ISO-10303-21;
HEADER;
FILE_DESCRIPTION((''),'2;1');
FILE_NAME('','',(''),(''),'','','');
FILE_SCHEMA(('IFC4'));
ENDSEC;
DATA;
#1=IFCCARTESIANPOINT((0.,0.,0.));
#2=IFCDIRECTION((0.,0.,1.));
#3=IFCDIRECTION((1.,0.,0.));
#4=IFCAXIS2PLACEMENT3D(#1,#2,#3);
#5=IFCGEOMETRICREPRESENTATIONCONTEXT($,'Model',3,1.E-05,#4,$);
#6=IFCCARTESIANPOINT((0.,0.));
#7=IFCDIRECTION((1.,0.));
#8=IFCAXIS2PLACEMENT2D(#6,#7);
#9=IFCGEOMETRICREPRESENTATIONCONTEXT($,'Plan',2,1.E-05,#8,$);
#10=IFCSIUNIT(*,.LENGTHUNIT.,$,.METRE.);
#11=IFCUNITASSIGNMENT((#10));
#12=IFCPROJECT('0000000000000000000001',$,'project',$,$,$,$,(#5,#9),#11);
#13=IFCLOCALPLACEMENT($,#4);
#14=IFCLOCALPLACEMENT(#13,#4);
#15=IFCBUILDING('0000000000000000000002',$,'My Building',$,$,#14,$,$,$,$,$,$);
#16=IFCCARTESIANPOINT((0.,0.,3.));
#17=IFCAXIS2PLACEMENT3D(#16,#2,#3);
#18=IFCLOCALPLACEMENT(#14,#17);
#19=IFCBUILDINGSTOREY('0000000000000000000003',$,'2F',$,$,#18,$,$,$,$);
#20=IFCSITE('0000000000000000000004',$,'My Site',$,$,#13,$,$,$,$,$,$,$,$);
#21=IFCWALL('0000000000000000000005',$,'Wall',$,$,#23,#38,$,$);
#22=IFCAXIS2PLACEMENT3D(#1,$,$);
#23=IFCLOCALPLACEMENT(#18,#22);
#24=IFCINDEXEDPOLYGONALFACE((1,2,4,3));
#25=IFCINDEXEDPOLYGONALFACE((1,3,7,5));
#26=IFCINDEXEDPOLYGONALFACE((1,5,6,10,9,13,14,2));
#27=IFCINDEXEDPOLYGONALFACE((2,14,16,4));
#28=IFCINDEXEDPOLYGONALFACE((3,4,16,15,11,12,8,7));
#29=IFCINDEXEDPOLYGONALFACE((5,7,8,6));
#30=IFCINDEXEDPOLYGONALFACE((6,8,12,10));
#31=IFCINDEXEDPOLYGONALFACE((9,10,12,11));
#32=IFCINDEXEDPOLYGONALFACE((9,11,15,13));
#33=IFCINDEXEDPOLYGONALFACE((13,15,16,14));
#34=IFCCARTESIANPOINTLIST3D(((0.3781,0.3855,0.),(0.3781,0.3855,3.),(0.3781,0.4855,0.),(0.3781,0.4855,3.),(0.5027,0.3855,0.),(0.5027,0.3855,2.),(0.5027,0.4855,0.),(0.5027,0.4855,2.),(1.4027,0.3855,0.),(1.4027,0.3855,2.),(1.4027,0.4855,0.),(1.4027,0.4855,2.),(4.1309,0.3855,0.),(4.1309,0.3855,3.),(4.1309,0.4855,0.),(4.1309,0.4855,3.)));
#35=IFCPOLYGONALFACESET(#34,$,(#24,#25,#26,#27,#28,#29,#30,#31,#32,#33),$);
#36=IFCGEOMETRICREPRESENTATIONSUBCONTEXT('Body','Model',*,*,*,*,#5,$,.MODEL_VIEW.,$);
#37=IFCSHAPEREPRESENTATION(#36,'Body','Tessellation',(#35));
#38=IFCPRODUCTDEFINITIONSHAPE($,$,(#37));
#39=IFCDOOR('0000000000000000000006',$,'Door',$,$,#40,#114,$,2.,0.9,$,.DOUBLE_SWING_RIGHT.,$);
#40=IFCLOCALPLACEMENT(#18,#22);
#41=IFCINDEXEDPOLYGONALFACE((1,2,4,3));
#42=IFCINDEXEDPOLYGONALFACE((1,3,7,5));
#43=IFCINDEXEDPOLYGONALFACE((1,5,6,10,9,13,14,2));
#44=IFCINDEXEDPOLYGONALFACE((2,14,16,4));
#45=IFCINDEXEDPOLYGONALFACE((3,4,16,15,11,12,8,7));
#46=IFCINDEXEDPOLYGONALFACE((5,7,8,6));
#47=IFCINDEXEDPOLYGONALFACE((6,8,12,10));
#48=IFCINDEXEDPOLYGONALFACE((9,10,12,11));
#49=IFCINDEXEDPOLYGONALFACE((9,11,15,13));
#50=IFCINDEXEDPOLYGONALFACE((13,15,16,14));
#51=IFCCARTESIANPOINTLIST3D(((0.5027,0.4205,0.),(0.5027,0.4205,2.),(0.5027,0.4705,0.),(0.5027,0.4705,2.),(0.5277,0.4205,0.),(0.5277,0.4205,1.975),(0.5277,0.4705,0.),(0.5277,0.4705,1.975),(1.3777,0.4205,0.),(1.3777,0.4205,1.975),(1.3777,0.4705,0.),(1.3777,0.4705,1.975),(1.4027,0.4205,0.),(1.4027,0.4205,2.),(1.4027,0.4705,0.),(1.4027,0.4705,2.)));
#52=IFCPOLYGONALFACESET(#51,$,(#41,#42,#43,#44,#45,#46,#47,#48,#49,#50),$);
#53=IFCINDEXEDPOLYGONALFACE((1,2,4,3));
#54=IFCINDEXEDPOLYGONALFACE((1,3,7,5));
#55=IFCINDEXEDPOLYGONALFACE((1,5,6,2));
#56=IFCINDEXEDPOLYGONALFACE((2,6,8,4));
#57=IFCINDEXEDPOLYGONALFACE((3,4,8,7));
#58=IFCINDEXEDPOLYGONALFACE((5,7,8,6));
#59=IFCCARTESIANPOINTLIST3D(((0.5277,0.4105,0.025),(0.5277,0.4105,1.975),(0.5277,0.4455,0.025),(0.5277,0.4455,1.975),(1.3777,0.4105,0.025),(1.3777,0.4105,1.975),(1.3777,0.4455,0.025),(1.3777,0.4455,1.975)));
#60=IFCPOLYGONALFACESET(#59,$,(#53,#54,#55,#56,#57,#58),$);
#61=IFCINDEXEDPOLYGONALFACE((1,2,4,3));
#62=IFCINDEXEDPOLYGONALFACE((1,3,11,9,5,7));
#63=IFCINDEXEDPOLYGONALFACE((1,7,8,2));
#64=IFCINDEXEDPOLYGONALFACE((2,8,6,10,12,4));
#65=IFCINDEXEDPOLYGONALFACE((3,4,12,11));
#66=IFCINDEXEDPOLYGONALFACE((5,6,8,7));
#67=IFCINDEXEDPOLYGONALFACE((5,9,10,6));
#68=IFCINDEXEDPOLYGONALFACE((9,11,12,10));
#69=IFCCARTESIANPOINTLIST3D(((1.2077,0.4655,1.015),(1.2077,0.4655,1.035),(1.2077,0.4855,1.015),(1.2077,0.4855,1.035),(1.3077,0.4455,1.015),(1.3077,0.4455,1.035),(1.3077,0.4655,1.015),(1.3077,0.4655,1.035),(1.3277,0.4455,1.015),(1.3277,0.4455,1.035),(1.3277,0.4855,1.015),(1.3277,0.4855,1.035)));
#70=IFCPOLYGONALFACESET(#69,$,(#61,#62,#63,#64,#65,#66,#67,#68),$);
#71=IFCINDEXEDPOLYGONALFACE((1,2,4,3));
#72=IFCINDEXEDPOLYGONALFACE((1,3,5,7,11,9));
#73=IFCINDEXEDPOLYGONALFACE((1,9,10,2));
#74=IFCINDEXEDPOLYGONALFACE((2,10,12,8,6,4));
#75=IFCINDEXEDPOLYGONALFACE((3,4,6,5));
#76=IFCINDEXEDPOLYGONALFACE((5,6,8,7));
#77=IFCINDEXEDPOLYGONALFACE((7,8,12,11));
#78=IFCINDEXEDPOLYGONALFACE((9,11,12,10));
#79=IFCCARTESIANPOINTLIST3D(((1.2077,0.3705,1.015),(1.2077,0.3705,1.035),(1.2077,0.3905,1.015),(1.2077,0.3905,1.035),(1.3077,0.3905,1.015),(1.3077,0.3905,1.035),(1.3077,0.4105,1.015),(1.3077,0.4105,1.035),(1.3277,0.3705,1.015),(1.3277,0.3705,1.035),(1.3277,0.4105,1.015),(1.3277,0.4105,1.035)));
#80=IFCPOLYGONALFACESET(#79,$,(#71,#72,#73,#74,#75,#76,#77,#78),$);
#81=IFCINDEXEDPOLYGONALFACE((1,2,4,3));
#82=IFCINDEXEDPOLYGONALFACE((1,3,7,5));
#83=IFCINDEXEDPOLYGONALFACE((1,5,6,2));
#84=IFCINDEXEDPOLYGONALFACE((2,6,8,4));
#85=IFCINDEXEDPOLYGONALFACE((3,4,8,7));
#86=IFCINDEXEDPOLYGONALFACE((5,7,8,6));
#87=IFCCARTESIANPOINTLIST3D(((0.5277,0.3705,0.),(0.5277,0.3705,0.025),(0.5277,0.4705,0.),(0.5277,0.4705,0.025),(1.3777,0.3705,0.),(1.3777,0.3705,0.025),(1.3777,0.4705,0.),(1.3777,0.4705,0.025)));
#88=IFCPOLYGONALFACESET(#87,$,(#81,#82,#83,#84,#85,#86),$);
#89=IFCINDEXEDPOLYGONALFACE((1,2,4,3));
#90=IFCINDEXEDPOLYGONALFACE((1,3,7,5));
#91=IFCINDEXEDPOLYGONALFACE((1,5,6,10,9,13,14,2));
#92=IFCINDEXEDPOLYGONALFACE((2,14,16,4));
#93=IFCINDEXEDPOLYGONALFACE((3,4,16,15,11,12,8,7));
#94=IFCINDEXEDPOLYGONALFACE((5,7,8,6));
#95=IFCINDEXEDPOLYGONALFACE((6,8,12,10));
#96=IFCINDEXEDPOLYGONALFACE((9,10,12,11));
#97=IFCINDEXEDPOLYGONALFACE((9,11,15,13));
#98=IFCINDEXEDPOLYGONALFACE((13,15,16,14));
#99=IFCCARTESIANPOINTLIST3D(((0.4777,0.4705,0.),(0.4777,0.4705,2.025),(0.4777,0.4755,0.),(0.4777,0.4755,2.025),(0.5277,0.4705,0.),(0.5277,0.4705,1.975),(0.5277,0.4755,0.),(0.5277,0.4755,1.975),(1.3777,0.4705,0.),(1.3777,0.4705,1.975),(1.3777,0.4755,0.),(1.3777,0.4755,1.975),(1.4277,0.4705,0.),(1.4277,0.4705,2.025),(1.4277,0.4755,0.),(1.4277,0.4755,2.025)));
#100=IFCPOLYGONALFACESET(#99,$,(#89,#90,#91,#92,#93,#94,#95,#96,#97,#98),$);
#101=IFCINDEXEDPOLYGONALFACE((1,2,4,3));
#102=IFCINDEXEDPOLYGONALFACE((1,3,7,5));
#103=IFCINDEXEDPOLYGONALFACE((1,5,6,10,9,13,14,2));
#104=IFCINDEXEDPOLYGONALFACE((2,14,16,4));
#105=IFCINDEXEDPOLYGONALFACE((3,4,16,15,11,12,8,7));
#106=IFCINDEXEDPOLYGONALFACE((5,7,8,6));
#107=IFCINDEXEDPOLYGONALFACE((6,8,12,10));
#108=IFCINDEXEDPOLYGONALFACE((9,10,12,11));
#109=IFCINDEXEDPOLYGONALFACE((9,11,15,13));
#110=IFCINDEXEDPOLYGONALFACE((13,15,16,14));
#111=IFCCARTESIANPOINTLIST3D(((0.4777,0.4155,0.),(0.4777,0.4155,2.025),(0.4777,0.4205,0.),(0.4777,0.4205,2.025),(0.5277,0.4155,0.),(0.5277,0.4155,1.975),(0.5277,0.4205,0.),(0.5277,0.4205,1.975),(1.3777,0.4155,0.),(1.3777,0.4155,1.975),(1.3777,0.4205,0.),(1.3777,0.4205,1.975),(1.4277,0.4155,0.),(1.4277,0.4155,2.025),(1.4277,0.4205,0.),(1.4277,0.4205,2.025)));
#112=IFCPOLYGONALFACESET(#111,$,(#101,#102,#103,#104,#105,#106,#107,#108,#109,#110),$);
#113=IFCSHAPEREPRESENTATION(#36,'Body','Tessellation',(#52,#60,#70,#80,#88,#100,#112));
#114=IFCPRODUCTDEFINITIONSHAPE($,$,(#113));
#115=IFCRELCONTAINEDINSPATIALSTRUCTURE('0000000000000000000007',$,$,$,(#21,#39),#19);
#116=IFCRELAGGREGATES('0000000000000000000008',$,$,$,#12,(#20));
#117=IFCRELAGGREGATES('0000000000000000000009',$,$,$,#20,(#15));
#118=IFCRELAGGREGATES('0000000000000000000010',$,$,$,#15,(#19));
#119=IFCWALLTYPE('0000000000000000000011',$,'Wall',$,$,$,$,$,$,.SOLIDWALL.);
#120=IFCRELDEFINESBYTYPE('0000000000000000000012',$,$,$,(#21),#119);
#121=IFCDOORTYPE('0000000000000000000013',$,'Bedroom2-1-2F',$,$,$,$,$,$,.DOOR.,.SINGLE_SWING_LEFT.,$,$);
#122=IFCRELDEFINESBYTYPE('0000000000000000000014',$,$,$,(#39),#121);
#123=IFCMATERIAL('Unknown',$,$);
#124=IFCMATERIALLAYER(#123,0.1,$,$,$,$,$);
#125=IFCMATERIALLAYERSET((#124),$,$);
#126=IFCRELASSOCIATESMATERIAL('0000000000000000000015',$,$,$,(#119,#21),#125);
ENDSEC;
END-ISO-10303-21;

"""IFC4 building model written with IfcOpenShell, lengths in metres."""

from ifc_helpers import new_model, entity, si_unit, frame, origin_with_axes, origin_2d_with_axis, place, context, subcontext, project, spatial, line, indexed_curve, outline, extrude, shape, source, transform, mapped, material, layer, layer_set, layer_usage, type_object, type_shapes, element, fill, save


model = new_model("IFC4")

# Units and contexts
model_context = context("Model", 3, precision=1e-05, world=origin_with_axes())
plan_context = context("Plan", 2, precision=1e-05, world=origin_2d_with_axis())
body_context_1 = subcontext(model_context, "Body", "Model", "MODEL_VIEW")
body_context_2 = subcontext(plan_context, "Body", "Plan", "PLAN_VIEW")
ifc_project = project(units=[si_unit("LENGTHUNIT", "METRE")], contexts=[model_context, plan_context])

# Site, building, storey
site_placement = place(None, origin_with_axes())
site = spatial("IfcSite", under=ifc_project, at=site_placement, Name="My Site")
building_placement = place(site_placement, origin_with_axes())
building = spatial("IfcBuilding", under=site, at=building_placement, Name="My Building")
storey_placement = place(building_placement, frame((0.0, 0.0, 3.0), z_axis=(0.0, 0.0, 1.0), x_axis=(1.0, 0.0, 0.0)))
storey = spatial("IfcBuildingStorey", under=building, at=storey_placement, Name="2F")

# Shared definitions
ifc_material = material(Name="Unknown")

# Shared definitions
ifc_layer_1 = layer(ifc_material, 0.1)
ifc_layer_set_1 = layer_set([ifc_layer_1])
wall_type = type_object("IfcWallType", Name="Wall", PredefinedType="SOLIDWALL", material=ifc_layer_set_1)

# Wall, opening, door
ifc_layer_usage_1 = layer_usage(ifc_layer_set_1, "AXIS2", "POSITIVE", 0.0)
wall_1_placement = place(storey_placement, frame((0.3781, 0.3855, 0.0), z_axis=(0.0, 0.0, 1.0), x_axis=(1.0, 0.0, 0.0)))
wall_1 = element("IfcWall", 1, at=wall_1_placement, inside=storey, type_object=wall_type, material=ifc_layer_usage_1, Name="Wall", context=body_context_1, shape_type="SweptSolid", body=[
    extrude(outline(indexed_curve([(0.0, 0.0), (0.0, 0.1), (3.7528, 0.1), (3.7528, 0.0)], segments=[line(1, 2, 3, 4, 1)])), origin_with_axes(), (0.0, 0.0, 1.0), 3.0),
])
shared_shape_1 = source(origin_with_axes(), body_context_1, "Body", "SweptSolid", [
    extrude(outline(indexed_curve([(0.0, 0.0), (0.9, 0.0), (0.9, 2.0), (0.0, 2.0)], segments=[line(1, 2, 3, 4, 1)])), frame((0.0, -0.6, 0.0), z_axis=(0.0, -1.0, 0.0), x_axis=(1.0, 0.0, 0.0)), (0.0, 0.0, -1.0), 1.2),
])
opening_1_placement = place(wall_1_placement, frame((1.0245, 0.085, 0.0), z_axis=(0.0, 0.0, 1.0), x_axis=(-1.0, 0.0, 0.0)))
opening_1 = element("IfcOpeningElement", 2, at=opening_1_placement, cuts=wall_1, PredefinedType="OPENING", context=body_context_1, shape_type="MappedRepresentation", body=[
    mapped(shared_shape_1, transform((0.0, 0.0, 0.0), x_axis=(1.0, 0.0, 0.0), y_axis=(0.0, 1.0, 0.0), z_axis=(0.0, 0.0, 1.0), scale=1.0)),
])
door_type_1 = type_object("IfcDoorType", Name="Bedroom2-1-2F", OperationType="SINGLE_SWING_LEFT", PredefinedType="DOOR")
shared_shape_2 = source(origin_with_axes(), body_context_1, "Body", "SweptSolid", [
    extrude(outline(indexed_curve([(0.0, 0.0), (0.0, 2.0), (0.9, 2.0), (0.9, 0.0), (0.875, 0.0), (0.875, 1.975), (0.025, 1.975), (0.025, 0.0)], segments=[line(1, 2, 3, 4, 5, 6, 7, 8, 1)])), frame((0.0, 0.0, 0.0), z_axis=(0.0, -1.0, 0.0), x_axis=(1.0, 0.0, 0.0)), (0.0, 0.0, -1.0), 0.05),
    extrude(outline(indexed_curve([(0.0, 0.0), (0.85, 0.0), (0.85, 0.035), (0.0, 0.035)], segments=[line(1, 2, 3, 4, 1)])), frame((0.025, 0.025, 0.025), z_axis=(0.0, 0.0, 1.0), x_axis=(1.0, 0.0, 0.0)), (0.0, 0.0, 1.0), 1.95),
    extrude(outline(indexed_curve([(0.0, 0.0), (0.0, -0.04), (0.12, -0.04), (0.12, -0.02), (0.02, -0.02), (0.02, 0.0)], segments=[line(1, 2, 3, 4, 5, 6, 1)])), frame((0.075, 0.025, 1.015), z_axis=(0.0, 0.0, 1.0), x_axis=(1.0, 0.0, 0.0)), (0.0, 0.0, 1.0), 0.02),
    extrude(outline(indexed_curve([(0.0, 0.0), (0.0, 0.04), (0.12, 0.04), (0.12, 0.02), (0.02, 0.02), (0.02, 0.0)], segments=[line(1, 2, 3, 4, 5, 6, 1)])), frame((0.075, 0.06, 1.015), z_axis=(0.0, 0.0, 1.0), x_axis=(1.0, 0.0, 0.0)), (0.0, 0.0, 1.0), 0.02),
    extrude(outline(indexed_curve([(0.0, 0.0), (0.85, 0.0), (0.85, 0.1), (0.0, 0.1)], segments=[line(1, 2, 3, 4, 1)])), frame((0.025, 0.0, 0.0), z_axis=(0.0, 0.0, 1.0), x_axis=(1.0, 0.0, 0.0)), (0.0, 0.0, 1.0), 0.025),
    extrude(outline(indexed_curve([(0.0, 0.0), (0.0, 2.025), (0.95, 2.025), (0.95, 0.0), (0.9, 0.0), (0.9, 1.975), (0.05, 1.975), (0.05, 0.0)], segments=[line(1, 2, 3, 4, 5, 6, 7, 8, 1)])), frame((-0.025, -0.005, 0.0), z_axis=(0.0, -1.0, 0.0), x_axis=(1.0, 0.0, 0.0)), (0.0, 0.0, -1.0), 0.005),
    extrude(outline(indexed_curve([(0.0, 0.0), (0.0, 2.025), (0.95, 2.025), (0.95, 0.0), (0.9, 0.0), (0.9, 1.975), (0.05, 1.975), (0.05, 0.0)], segments=[line(1, 2, 3, 4, 5, 6, 7, 8, 1)])), frame((-0.025, 0.05, 0.0), z_axis=(0.0, -1.0, 0.0), x_axis=(1.0, 0.0, 0.0)), (0.0, 0.0, -1.0), 0.005),
])
shared_shape_3 = source(origin_with_axes(), body_context_2, "Body", "Curve2D", [
    entity("IfcIndexedPolyCurve", entity("IfcCartesianPointList2D", [[0.0, 0.0], [0.025, 0.0], [0.025, 0.05], [0.0, 0.05]]), [entity("IfcLineIndex", [1, 2, 3, 4, 1])]),
    entity("IfcIndexedPolyCurve", entity("IfcCartesianPointList2D", [[0.9, 0.0], [0.875, 0.0], [0.875, 0.05], [0.9, 0.05]]), [entity("IfcLineIndex", [1, 2, 3, 4, 1])]),
    entity("IfcIndexedPolyCurve", entity("IfcCartesianPointList2D", [[0.875, 0.05], [0.875, -0.8], [0.84, -0.8]])),
    entity("IfcTrimmedCurve", entity("IfcEllipse", entity("IfcAxis2Placement2D", entity("IfcCartesianPoint", [0.84, 0.05]), entity("IfcDirection", [1.0, 0.0])), 0.815, 0.85), [entity("IfcCartesianPoint", [0.84, 0.9])], [entity("IfcCartesianPoint", [0.84, -0.8])], True, "CARTESIAN"),
    entity("IfcIndexedPolyCurve", entity("IfcCartesianPointList2D", [[0.875, 0.05], [0.84, 0.05], [0.84, 0.9], [0.875, 0.9]]), [entity("IfcLineIndex", [1, 2, 3, 4, 1])]),
])
type_shapes(door_type_1, [shared_shape_2, shared_shape_3])
door_1_placement = place(opening_1_placement, origin_with_axes())
door_1 = element("IfcDoor", 3, at=door_1_placement, inside=storey, type_object=door_type_1, Name="Door", OperationType="DOUBLE_SWING_RIGHT", OverallHeight=2.0, OverallWidth=0.9, shapes=[
    shape(body_context_1, "Body", "MappedRepresentation", [mapped(shared_shape_2, transform((0.0, 0.0, 0.0), x_axis=(1.0, 0.0, 0.0), y_axis=(0.0, 1.0, 0.0), z_axis=(0.0, 0.0, 1.0), scale=1.0))]),
    shape(body_context_2, "Body", "MappedRepresentation", [mapped(shared_shape_3, transform((0.0, 0.0, 0.0), x_axis=(1.0, 0.0, 0.0), y_axis=(0.0, 1.0, 0.0), z_axis=(0.0, 0.0, 1.0), scale=1.0))]),
])
fill(opening_1, door_1)

save(model, "model.ifc")
